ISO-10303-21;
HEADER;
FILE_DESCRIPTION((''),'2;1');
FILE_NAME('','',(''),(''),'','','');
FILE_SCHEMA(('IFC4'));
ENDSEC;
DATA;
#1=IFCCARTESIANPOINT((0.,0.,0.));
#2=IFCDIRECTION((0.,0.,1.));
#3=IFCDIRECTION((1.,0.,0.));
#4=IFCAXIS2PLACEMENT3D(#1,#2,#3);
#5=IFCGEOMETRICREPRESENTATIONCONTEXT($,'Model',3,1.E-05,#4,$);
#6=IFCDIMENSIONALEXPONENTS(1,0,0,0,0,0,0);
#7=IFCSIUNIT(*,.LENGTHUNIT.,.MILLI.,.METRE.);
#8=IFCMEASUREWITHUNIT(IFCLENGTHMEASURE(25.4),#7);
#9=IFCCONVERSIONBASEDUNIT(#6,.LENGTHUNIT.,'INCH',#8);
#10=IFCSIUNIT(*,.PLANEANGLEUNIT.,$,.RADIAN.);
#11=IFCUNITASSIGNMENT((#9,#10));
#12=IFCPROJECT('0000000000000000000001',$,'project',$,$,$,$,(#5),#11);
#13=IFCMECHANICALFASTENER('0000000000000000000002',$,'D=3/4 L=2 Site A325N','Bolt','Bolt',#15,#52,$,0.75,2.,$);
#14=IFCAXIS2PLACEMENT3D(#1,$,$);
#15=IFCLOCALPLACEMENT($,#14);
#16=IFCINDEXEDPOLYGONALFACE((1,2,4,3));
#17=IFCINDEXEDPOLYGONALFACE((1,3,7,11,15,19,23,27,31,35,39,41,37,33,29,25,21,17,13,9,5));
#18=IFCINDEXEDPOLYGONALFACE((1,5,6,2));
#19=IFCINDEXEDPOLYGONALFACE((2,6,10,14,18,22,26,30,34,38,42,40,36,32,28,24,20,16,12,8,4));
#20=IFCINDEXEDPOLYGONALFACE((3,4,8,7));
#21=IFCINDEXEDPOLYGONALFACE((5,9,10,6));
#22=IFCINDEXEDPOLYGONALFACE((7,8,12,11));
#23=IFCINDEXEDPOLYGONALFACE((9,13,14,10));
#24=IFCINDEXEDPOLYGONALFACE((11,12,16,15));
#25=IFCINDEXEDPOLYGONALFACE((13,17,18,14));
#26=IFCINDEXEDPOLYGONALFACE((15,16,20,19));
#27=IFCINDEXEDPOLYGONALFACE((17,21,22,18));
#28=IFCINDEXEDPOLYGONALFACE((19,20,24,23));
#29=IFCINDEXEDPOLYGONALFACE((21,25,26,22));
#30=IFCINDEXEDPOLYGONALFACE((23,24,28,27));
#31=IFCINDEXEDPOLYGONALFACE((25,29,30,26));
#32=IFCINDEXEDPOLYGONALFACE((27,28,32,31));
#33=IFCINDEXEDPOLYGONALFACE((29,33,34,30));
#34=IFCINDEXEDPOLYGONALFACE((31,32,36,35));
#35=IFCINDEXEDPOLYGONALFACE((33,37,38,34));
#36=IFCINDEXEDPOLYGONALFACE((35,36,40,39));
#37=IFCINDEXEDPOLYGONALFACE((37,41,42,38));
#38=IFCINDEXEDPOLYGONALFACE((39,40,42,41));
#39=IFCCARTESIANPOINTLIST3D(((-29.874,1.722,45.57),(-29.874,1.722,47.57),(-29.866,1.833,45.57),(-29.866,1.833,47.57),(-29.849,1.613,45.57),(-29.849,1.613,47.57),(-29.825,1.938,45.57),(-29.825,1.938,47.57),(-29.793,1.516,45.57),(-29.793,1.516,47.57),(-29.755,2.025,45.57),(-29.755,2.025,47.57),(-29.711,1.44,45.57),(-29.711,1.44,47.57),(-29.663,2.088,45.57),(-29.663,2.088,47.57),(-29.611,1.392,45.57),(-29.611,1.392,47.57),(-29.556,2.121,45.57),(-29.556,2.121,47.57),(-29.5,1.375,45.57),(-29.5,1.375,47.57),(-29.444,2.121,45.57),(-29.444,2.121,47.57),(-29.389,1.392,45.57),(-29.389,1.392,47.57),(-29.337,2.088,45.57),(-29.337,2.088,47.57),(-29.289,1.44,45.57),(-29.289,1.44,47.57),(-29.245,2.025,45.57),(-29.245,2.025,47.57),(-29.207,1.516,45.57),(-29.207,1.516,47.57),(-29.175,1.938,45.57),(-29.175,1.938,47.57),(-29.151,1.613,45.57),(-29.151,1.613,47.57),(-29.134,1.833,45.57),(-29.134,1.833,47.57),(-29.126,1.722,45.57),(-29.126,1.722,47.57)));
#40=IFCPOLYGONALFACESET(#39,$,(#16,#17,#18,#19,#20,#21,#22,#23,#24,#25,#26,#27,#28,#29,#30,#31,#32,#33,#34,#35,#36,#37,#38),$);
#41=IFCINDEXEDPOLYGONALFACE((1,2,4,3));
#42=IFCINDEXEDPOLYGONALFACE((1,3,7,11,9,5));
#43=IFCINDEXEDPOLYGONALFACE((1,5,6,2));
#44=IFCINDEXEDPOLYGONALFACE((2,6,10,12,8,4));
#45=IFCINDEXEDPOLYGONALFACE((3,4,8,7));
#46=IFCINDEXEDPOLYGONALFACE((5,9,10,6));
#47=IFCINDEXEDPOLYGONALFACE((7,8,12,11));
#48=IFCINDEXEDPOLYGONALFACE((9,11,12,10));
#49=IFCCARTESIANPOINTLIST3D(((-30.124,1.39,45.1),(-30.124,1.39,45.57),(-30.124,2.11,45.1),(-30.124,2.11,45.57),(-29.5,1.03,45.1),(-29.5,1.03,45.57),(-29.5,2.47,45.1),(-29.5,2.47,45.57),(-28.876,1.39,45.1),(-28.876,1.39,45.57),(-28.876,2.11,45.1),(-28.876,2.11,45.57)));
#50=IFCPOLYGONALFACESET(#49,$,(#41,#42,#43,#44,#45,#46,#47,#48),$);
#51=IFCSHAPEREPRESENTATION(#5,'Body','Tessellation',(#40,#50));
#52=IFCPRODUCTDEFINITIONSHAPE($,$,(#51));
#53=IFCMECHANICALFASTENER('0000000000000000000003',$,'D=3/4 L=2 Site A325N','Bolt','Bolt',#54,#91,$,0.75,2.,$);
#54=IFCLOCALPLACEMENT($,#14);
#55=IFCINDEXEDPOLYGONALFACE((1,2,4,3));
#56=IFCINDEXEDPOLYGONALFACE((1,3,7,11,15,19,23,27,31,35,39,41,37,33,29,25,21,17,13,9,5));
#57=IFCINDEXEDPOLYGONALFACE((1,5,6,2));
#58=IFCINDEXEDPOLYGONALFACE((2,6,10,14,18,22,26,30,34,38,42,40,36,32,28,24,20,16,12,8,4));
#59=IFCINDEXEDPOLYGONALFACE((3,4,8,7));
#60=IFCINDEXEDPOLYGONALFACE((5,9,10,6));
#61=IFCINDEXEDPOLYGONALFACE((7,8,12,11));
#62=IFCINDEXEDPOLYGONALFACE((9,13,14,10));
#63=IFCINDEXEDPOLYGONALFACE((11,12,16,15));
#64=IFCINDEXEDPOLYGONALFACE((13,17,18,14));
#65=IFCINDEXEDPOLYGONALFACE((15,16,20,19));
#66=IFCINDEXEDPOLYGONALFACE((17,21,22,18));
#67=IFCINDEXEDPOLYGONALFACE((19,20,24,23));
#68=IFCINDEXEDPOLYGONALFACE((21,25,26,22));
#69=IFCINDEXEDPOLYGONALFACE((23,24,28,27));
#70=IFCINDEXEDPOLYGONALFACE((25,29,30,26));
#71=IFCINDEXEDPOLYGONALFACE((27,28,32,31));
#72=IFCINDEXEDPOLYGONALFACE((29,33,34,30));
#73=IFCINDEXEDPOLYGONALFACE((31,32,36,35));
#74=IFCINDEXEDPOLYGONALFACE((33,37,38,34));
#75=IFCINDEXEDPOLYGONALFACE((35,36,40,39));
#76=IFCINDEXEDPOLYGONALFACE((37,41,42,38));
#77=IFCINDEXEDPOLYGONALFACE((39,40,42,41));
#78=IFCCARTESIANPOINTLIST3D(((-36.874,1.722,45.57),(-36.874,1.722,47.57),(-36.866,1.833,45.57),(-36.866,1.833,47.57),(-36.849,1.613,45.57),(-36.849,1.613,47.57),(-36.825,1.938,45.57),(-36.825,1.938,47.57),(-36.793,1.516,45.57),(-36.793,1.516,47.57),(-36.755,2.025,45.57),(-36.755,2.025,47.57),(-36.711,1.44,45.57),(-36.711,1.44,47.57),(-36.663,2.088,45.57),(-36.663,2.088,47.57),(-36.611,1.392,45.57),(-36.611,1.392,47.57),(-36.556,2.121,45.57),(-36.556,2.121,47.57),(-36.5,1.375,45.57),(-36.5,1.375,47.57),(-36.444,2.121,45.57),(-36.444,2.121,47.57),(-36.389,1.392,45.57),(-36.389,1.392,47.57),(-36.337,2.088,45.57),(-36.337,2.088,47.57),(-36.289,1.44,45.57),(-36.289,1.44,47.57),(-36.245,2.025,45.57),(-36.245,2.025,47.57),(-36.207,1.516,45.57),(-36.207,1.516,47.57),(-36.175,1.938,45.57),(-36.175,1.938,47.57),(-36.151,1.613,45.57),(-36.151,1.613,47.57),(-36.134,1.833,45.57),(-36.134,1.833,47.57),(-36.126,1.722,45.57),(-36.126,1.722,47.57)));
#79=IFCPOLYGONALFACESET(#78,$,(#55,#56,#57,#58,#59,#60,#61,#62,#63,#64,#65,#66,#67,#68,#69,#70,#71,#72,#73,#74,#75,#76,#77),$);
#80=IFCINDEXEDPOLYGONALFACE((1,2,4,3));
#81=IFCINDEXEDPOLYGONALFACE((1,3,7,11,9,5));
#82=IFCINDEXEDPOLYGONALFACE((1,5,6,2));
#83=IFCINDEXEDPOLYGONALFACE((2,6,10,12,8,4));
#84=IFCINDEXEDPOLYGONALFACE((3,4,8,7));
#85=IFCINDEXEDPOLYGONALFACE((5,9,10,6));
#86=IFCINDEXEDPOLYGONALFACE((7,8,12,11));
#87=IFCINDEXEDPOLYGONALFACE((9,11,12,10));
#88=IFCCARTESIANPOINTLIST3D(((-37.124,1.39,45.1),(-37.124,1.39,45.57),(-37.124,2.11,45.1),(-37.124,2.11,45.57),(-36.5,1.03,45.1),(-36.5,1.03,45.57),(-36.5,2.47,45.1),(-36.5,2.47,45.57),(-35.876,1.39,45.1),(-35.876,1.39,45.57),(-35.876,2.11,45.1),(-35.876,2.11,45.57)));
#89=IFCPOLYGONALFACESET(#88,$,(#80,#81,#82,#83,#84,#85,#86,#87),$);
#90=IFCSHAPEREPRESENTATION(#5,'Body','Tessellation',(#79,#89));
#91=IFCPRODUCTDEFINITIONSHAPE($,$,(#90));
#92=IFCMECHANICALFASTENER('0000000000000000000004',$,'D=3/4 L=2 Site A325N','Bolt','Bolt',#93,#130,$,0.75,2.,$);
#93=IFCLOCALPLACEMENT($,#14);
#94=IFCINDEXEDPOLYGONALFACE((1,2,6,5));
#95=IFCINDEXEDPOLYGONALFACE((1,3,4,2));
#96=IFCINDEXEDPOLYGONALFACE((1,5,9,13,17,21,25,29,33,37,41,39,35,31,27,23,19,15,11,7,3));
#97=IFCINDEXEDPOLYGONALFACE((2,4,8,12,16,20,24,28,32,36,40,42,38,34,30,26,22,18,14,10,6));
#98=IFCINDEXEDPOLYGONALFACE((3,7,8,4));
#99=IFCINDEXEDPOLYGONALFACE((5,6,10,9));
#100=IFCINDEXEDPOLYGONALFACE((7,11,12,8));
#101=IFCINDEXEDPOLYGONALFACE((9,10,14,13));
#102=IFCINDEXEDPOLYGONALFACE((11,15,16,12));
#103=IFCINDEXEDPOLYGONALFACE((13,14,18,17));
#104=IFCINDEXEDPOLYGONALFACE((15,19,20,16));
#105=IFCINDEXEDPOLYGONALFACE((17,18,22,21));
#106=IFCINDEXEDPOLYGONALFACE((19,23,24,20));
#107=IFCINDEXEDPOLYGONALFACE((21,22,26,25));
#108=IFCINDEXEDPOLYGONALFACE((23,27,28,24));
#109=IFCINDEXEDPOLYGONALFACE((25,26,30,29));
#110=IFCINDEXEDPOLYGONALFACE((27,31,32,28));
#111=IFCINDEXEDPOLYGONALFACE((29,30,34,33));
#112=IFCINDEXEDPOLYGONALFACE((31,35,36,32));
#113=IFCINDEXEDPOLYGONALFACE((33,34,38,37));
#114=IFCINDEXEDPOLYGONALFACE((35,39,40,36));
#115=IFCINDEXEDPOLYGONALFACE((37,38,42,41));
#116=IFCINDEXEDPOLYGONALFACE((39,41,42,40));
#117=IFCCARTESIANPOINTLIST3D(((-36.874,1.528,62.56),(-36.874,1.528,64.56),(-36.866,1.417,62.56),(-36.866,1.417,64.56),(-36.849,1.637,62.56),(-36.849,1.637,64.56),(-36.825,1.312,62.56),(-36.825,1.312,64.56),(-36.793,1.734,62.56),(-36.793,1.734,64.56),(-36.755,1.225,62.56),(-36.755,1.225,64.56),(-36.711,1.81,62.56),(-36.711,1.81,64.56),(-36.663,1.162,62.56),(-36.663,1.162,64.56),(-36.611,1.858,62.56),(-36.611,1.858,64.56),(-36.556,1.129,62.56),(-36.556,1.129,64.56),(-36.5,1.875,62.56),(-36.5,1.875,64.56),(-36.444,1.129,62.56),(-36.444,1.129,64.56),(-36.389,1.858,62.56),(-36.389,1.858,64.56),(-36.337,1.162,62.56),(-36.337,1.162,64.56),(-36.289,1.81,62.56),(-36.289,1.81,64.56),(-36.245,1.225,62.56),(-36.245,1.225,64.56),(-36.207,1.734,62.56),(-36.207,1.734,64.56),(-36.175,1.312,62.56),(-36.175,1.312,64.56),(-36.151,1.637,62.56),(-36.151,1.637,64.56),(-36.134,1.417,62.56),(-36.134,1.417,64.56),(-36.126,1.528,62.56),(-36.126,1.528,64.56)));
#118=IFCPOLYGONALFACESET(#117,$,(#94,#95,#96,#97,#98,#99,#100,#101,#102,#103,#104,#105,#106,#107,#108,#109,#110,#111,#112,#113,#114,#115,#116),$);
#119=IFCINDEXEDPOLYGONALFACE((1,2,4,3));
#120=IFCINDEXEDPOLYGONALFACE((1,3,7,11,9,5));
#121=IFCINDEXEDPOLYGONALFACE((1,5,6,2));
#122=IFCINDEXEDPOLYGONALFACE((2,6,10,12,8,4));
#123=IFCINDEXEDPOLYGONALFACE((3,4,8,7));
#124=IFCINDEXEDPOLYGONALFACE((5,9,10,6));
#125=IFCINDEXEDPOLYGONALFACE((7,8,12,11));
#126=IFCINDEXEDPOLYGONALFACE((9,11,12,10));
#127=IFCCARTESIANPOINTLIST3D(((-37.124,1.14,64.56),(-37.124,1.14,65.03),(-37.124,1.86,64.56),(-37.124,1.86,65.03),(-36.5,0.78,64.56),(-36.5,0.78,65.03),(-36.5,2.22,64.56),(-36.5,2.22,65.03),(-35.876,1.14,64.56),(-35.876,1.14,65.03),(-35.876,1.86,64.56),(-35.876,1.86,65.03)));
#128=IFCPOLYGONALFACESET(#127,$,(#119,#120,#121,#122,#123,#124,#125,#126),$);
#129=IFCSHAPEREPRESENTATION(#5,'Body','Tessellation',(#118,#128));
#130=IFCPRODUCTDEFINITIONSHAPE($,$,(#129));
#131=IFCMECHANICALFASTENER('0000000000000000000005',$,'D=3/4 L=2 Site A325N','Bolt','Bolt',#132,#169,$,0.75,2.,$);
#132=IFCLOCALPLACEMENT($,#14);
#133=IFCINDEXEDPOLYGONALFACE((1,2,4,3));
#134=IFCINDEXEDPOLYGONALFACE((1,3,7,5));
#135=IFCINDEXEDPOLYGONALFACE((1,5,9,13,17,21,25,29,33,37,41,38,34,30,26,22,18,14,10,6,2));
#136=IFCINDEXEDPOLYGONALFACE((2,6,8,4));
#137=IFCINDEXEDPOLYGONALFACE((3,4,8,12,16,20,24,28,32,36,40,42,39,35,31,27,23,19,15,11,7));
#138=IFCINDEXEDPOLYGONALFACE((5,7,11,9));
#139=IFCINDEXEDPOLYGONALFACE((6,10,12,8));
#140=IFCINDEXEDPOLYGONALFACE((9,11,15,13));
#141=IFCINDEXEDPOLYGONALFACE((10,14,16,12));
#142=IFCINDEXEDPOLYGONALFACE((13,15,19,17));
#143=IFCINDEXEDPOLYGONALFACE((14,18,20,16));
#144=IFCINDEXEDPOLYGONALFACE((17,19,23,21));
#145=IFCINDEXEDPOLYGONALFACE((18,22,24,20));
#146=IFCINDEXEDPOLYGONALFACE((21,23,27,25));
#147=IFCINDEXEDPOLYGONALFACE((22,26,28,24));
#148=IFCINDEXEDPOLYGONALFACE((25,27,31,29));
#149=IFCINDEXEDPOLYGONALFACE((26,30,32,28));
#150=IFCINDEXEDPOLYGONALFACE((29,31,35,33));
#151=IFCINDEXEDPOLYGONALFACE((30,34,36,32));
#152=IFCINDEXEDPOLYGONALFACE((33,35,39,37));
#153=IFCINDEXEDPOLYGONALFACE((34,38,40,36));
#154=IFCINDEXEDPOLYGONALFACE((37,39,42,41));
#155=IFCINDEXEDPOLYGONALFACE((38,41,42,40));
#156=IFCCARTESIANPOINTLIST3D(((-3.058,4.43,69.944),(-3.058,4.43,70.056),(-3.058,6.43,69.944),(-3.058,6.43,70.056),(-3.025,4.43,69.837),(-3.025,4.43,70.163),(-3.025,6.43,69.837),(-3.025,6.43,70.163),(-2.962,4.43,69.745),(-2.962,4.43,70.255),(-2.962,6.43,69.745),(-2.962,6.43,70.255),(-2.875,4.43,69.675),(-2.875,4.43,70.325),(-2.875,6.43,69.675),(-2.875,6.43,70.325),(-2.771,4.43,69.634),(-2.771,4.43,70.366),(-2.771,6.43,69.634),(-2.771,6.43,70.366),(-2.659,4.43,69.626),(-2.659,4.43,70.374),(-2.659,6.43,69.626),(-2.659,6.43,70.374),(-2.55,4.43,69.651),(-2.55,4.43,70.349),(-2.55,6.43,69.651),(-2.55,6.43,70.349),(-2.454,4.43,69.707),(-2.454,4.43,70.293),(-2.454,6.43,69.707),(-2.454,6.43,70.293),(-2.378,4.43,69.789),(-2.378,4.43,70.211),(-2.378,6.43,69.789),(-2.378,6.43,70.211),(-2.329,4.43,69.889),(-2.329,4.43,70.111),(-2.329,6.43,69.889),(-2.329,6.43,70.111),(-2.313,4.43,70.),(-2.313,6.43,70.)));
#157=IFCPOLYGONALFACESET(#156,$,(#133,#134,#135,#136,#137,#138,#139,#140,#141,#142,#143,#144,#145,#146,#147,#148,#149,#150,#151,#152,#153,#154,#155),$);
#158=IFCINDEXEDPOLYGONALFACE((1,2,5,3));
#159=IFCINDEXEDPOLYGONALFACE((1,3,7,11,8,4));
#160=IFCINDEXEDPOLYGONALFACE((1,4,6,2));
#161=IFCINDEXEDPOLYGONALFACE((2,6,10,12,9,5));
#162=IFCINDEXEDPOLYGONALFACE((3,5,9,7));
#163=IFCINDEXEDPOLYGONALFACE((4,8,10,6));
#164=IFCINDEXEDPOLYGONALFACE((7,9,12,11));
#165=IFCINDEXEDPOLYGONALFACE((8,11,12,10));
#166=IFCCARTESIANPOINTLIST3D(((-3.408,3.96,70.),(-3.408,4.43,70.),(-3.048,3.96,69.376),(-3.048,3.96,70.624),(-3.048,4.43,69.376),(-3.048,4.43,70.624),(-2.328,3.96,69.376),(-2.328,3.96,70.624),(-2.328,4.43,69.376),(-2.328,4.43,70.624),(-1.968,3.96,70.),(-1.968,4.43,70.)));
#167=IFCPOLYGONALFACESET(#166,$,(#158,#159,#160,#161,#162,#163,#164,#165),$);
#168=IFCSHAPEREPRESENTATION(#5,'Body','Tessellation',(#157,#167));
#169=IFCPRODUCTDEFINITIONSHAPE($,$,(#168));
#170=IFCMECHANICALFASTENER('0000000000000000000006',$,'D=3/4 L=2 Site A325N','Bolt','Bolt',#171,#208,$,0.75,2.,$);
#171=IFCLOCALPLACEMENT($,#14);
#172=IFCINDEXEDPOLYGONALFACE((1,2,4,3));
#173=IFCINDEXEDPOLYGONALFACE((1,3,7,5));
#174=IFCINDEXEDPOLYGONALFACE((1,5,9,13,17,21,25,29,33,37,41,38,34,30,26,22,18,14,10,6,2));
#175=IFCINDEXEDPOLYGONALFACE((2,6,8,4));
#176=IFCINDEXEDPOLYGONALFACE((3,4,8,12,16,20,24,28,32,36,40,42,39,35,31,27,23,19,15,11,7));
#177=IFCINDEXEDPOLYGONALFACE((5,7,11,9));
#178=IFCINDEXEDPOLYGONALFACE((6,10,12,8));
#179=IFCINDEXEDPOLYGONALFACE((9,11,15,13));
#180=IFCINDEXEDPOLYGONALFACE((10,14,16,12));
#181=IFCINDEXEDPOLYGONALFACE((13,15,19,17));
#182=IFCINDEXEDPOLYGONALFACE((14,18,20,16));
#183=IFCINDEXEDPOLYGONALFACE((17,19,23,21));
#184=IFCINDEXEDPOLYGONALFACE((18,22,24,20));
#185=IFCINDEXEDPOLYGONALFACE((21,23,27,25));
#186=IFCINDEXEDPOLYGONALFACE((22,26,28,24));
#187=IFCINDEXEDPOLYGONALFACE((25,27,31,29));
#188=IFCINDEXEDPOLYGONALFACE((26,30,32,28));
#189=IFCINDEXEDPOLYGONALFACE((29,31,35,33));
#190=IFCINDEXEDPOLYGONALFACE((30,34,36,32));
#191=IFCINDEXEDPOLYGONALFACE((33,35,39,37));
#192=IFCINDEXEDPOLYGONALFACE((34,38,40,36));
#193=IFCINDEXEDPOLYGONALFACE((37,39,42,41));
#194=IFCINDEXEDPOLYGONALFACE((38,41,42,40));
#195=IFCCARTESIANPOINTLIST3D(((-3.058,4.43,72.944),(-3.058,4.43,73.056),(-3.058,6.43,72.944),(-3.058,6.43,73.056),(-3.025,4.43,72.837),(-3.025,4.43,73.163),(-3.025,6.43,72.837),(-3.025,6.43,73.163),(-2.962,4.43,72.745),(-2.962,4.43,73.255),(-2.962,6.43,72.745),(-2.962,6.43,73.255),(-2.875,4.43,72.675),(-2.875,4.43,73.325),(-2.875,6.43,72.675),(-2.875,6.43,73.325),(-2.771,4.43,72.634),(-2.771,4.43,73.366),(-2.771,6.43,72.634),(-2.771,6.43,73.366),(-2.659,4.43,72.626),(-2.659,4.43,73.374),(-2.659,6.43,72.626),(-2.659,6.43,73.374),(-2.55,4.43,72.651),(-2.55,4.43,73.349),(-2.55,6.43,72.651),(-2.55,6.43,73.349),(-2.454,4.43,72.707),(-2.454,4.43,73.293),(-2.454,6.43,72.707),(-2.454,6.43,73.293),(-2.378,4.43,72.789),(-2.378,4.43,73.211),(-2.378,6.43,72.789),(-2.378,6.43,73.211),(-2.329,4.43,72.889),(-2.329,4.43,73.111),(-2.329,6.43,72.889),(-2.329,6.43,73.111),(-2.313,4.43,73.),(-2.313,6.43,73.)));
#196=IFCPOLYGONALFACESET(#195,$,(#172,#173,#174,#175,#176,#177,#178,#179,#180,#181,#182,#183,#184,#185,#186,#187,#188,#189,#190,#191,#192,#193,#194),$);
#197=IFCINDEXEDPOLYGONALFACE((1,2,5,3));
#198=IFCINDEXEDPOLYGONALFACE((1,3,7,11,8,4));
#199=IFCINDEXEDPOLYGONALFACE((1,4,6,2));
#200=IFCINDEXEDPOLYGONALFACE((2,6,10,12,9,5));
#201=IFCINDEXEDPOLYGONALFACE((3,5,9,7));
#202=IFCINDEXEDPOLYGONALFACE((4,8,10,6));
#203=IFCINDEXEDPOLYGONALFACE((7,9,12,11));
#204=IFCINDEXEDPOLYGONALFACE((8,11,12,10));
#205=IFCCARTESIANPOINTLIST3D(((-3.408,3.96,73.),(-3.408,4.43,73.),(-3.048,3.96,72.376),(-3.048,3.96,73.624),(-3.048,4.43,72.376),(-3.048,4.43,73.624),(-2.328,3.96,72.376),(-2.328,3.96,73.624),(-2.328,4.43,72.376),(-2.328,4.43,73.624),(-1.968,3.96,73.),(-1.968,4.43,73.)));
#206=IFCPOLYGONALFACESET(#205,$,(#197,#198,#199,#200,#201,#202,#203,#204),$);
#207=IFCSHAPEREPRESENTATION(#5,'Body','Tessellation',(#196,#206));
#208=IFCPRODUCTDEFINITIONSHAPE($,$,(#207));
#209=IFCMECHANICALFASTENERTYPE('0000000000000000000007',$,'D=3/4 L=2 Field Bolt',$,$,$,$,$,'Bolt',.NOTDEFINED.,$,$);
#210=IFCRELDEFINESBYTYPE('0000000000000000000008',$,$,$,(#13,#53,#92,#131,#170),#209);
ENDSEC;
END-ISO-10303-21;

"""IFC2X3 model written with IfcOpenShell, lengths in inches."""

from ifc_helpers import new_model, entity, si_unit, converted_unit, frame, origin_with_axes, origin_2d_with_axis, place, context, project, polyline, circle, outline, extrude, source, transform, mapped, type_object, type_shapes, element, save


model = new_model("IFC2X3")

# Units and contexts
model_context = context("Model", 3, precision=1e-05, world=origin_with_axes())
ifc_project = project(units=[converted_unit("LENGTHUNIT", "INCH", entity("IfcLengthMeasure", 25.4), si_unit("LENGTHUNIT", "METRE", prefix="MILLI"), dimensions=[1, 0, 0, 0, 0, 0, 0]), si_unit("PLANEANGLEUNIT", "RADIAN")], contexts=[model_context])

# Mechanical fasteners
placement_1 = place(None, origin_with_axes())
placement_2 = place(placement_1, origin_with_axes())
placement_3 = place(placement_2, frame((0.0, 0.0, 80.0), z_axis=(0.0, 0.0, 1.0), x_axis=(0.0, 1.0, 0.0)))
mechanical_fastener_type_1 = type_object("IfcMechanicalFastenerType", Name="D=3/4 L=2 Field Bolt", ElementType="Bolt")
shared_shape_1 = source(origin_with_axes(), model_context, "Body", "SweptSolid", [
    extrude(circle(Radius=0.375, at=origin_2d_with_axis()), frame((0.0, 0.0, 0.0), z_axis=(1.0, 0.0, 0.0), x_axis=(0.0, 1.0, 0.0)), (0.0, 0.0, 1.0), 2.0),
    extrude(outline(polyline([(-0.72, 0.0), (-0.36, 0.624), (0.36, 0.624), (0.72, 0.0), (0.36, -0.624), (-0.36, -0.624), (-0.72, 0.0)])), frame((0.0, 0.0, 0.0), z_axis=(1.0, 0.0, 0.0), x_axis=(0.0, 1.0, 0.0)), (0.0, 0.0, -1.0), 0.47),
])
type_shapes(mechanical_fastener_type_1, [shared_shape_1])
placement_4 = place(placement_2, frame((-33.0, 0.0, 46.0), z_axis=(-1.0, 0.0, 0.0), x_axis=(0.0, 0.0, 1.0)))
placement_5 = place(placement_4, frame((-0.43, 1.75, 3.5), z_axis=(0.0, 0.0, -1.0), x_axis=(1.0, 0.0, 0.0)))
for number, where, z_axis, x_axis, name in (
    (1, (0.0, 0.0, 7.0), (0.0, 0.0, 1.0), (1.0, 0.0, 0.0), "D=3/4 L=2 Site A325N"),
    (2, (0.0, 0.0, 0.0), (0.0, 0.0, 1.0), (1.0, 0.0, 0.0), "D=3/4 L=2 Site A325N"),
):
    element("IfcMechanicalFastener", number, at=place(placement_5, frame(where, z_axis=z_axis, x_axis=x_axis)), type_object=mechanical_fastener_type_1, Name=name, Description="Bolt", ObjectType="Bolt", NominalDiameter=0.75, NominalLength=2.0, context=model_context, shape_type="MappedRepresentation", body=[
        mapped(shared_shape_1, transform((0.0, 0.0, 0.0), scale=1.0)),
    ])
placement_6 = place(placement_4, frame((18.56, -1.5, 3.5), z_axis=(0.0, 0.0, -1.0), x_axis=(-1.0, 0.0, 0.0)))
for number, where, z_axis, x_axis, name in (
    (3, (0.0, 3.0, 0.0), (0.0, 0.0, 1.0), (1.0, 0.0, 0.0), "D=3/4 L=2 Site A325N"),
):
    element("IfcMechanicalFastener", number, at=place(placement_6, frame(where, z_axis=z_axis, x_axis=x_axis)), type_object=mechanical_fastener_type_1, Name=name, Description="Bolt", ObjectType="Bolt", NominalDiameter=0.75, NominalLength=2.0, context=model_context, shape_type="MappedRepresentation", body=[
        mapped(shared_shape_1, transform((0.0, 0.0, 0.0), scale=1.0)),
    ])
placement_7 = place(placement_3, frame((4.43, 2.688, -4.0), z_axis=(0.0, 0.0, -1.0), x_axis=(1.0, 0.0, 0.0)))
for number, where, z_axis, x_axis, name in (
    (4, (0.0, 0.0, 6.0), (0.0, 0.0, 1.0), (1.0, 0.0, 0.0), "D=3/4 L=2 Site A325N"),
    (5, (0.0, 0.0, 3.0), (0.0, 0.0, 1.0), (1.0, 0.0, 0.0), "D=3/4 L=2 Site A325N"),
):
    element("IfcMechanicalFastener", number, at=place(placement_7, frame(where, z_axis=z_axis, x_axis=x_axis)), type_object=mechanical_fastener_type_1, Name=name, Description="Bolt", ObjectType="Bolt", NominalDiameter=0.75, NominalLength=2.0, context=model_context, shape_type="MappedRepresentation", body=[
        mapped(shared_shape_1, transform((0.0, 0.0, 0.0), scale=1.0)),
    ])

save(model, "model.ifc")
